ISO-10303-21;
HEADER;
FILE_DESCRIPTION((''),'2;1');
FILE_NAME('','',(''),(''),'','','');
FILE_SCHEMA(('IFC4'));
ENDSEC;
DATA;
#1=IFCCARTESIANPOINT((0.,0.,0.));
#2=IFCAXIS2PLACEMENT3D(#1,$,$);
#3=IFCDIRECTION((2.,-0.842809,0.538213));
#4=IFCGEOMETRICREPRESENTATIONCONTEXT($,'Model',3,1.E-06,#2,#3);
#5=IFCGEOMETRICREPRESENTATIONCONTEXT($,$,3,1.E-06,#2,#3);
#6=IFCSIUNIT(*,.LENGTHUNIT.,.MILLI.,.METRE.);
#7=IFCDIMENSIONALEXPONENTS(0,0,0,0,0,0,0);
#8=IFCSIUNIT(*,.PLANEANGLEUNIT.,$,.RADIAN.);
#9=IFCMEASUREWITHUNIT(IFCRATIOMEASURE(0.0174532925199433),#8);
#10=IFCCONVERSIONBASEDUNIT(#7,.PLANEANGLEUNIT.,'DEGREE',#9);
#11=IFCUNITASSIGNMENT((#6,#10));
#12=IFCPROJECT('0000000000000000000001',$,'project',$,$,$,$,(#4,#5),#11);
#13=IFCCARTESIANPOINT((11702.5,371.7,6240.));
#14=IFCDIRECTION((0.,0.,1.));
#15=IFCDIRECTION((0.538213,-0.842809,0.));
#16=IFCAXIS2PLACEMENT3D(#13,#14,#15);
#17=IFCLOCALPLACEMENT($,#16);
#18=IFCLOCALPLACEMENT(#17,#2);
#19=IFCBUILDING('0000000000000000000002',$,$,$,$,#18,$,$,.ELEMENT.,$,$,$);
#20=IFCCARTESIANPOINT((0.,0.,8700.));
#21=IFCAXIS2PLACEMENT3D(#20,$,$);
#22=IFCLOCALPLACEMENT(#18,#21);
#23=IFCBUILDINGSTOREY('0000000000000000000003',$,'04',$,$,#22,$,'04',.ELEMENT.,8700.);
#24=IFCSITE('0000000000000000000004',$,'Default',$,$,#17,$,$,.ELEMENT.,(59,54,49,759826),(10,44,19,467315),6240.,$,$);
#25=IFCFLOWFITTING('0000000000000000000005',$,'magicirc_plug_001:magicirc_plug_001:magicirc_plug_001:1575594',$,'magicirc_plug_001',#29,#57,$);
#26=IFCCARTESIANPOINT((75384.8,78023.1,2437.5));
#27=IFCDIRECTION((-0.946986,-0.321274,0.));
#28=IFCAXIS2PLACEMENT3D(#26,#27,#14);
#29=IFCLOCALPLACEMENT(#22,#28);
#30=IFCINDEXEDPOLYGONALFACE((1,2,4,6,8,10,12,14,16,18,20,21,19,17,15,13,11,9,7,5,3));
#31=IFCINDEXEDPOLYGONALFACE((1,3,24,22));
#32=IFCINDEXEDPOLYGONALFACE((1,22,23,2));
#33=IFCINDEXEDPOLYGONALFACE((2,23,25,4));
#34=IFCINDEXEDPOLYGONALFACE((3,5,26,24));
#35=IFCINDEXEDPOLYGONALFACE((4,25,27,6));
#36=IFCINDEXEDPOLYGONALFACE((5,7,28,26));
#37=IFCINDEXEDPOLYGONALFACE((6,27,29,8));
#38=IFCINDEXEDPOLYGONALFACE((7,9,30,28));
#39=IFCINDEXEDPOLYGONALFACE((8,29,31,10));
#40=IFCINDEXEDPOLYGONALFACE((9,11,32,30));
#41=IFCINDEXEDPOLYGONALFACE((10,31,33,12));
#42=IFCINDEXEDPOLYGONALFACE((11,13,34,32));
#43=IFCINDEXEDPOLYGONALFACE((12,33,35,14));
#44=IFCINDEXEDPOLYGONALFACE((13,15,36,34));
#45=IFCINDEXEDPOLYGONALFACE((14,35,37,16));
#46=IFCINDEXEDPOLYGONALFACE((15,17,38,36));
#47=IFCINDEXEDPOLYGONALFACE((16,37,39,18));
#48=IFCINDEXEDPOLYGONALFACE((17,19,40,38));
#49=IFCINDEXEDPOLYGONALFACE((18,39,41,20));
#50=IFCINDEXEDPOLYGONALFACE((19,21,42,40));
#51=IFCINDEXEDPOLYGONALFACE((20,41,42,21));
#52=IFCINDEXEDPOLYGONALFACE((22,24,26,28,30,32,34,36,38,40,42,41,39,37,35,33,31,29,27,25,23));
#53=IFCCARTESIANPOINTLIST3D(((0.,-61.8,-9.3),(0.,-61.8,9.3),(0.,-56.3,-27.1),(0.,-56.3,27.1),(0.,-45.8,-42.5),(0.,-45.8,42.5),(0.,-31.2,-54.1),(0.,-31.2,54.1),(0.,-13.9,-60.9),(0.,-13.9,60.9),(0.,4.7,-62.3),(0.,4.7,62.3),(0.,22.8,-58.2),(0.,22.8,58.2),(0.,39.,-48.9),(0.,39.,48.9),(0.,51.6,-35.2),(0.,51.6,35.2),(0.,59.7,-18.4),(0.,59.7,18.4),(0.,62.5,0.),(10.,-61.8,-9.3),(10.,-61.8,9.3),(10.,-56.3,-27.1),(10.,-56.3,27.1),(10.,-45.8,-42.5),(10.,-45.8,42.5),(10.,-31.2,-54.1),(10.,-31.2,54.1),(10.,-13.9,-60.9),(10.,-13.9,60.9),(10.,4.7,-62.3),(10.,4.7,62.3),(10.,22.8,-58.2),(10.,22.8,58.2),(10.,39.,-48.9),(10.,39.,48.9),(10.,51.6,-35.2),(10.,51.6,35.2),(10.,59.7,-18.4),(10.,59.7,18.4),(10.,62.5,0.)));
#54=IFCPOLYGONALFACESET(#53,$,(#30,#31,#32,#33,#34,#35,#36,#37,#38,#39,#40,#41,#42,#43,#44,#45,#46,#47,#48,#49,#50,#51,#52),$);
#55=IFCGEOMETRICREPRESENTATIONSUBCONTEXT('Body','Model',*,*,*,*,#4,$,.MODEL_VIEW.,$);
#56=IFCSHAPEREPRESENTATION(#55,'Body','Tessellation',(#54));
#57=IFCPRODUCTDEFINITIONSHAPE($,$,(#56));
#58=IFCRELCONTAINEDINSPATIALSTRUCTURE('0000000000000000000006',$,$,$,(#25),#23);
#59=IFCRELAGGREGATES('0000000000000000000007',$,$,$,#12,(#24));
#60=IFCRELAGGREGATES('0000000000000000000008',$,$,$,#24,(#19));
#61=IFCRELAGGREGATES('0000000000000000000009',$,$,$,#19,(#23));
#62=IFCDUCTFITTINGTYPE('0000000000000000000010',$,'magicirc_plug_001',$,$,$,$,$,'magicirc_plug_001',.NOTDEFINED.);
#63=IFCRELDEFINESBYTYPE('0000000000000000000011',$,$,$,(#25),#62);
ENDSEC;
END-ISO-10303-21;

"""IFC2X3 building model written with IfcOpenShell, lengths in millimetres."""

from ifc_helpers import new_model, entity, si_unit, converted_unit, direction, frame, frame_2d, origin, place, context, subcontext, project, spatial, circle, extrude, source, transform, mapped, type_object, type_shapes, element, save


model = new_model("IFC2X3")

# Units and contexts
model_context = context("Model", 3, precision=1e-06, world=origin(), true_north=direction((2.0, -0.842809, 0.538213)))
context_of_model = context(None, 3, precision=1e-06, world=origin(), true_north=direction((2.0, -0.842809, 0.538213)))
body_context = subcontext(model_context, "Body", "Model", "MODEL_VIEW")
ifc_project = project(units=[si_unit("LENGTHUNIT", "METRE", prefix="MILLI"), converted_unit("PLANEANGLEUNIT", "DEGREE", entity("IfcRatioMeasure", 0.0174532925199433), si_unit("PLANEANGLEUNIT", "RADIAN"), dimensions=[0, 0, 0, 0, 0, 0, 0])], contexts=[model_context, context_of_model])

# Site, building, storey
site_placement = place(None, frame((11702.5, 371.7, 6240.0), z_axis=(0.0, 0.0, 1.0), x_axis=(0.538213, -0.842809, 0.0)))
site = spatial("IfcSite", under=ifc_project, at=site_placement, Name="Default", CompositionType="ELEMENT", RefLatitude=(59, 54, 49, 759826), RefLongitude=(10, 44, 19, 467315), RefElevation=6240.0)
building_placement = place(site_placement, origin())
building = spatial("IfcBuilding", under=site, at=building_placement, CompositionType="ELEMENT")
storey_placement = place(building_placement, frame((0.0, 0.0, 8700.0)))
storey = spatial("IfcBuildingStorey", under=building, at=storey_placement, Name="04", LongName="04", CompositionType="ELEMENT", Elevation=8700.0)

# Flow fitting
duct_fitting_type_1 = type_object("IfcDuctFittingType", Name="magicirc_plug_001", ElementType="magicirc_plug_001", PredefinedType="NOTDEFINED")
shared_shape_1 = source(origin(), body_context, "Body", "SweptSolid", [
    extrude(circle(Radius=62.5, at=frame_2d((0.0, 0.0), x_axis=(1.0, 0.0))), frame((0.0, 0.0, 0.0), z_axis=(1.0, 0.0, 0.0), x_axis=(0.0, 1.0, 0.0)), (0.0, 0.0, 1.0), 10.0),
])
type_shapes(duct_fitting_type_1, [shared_shape_1])
for number, where, z_axis, x_axis, name in (
    (1, (75384.8, 78023.1, 2437.5), (-0.946986, -0.321274, 0.0), (0.0, 0.0, 1.0), "magicirc_plug_001:magicirc_plug_001:magicirc_plug_001:1575594"),
):
    element("IfcFlowFitting", number, at=place(storey_placement, frame(where, z_axis=z_axis, x_axis=x_axis)), inside=storey, type_object=duct_fitting_type_1, Name=name, ObjectType="magicirc_plug_001", context=body_context, shape_type="MappedRepresentation", body=[
        mapped(shared_shape_1, transform((0.0, 0.0, 0.0), scale=1.0)),
    ])

save(model, "model.ifc")
